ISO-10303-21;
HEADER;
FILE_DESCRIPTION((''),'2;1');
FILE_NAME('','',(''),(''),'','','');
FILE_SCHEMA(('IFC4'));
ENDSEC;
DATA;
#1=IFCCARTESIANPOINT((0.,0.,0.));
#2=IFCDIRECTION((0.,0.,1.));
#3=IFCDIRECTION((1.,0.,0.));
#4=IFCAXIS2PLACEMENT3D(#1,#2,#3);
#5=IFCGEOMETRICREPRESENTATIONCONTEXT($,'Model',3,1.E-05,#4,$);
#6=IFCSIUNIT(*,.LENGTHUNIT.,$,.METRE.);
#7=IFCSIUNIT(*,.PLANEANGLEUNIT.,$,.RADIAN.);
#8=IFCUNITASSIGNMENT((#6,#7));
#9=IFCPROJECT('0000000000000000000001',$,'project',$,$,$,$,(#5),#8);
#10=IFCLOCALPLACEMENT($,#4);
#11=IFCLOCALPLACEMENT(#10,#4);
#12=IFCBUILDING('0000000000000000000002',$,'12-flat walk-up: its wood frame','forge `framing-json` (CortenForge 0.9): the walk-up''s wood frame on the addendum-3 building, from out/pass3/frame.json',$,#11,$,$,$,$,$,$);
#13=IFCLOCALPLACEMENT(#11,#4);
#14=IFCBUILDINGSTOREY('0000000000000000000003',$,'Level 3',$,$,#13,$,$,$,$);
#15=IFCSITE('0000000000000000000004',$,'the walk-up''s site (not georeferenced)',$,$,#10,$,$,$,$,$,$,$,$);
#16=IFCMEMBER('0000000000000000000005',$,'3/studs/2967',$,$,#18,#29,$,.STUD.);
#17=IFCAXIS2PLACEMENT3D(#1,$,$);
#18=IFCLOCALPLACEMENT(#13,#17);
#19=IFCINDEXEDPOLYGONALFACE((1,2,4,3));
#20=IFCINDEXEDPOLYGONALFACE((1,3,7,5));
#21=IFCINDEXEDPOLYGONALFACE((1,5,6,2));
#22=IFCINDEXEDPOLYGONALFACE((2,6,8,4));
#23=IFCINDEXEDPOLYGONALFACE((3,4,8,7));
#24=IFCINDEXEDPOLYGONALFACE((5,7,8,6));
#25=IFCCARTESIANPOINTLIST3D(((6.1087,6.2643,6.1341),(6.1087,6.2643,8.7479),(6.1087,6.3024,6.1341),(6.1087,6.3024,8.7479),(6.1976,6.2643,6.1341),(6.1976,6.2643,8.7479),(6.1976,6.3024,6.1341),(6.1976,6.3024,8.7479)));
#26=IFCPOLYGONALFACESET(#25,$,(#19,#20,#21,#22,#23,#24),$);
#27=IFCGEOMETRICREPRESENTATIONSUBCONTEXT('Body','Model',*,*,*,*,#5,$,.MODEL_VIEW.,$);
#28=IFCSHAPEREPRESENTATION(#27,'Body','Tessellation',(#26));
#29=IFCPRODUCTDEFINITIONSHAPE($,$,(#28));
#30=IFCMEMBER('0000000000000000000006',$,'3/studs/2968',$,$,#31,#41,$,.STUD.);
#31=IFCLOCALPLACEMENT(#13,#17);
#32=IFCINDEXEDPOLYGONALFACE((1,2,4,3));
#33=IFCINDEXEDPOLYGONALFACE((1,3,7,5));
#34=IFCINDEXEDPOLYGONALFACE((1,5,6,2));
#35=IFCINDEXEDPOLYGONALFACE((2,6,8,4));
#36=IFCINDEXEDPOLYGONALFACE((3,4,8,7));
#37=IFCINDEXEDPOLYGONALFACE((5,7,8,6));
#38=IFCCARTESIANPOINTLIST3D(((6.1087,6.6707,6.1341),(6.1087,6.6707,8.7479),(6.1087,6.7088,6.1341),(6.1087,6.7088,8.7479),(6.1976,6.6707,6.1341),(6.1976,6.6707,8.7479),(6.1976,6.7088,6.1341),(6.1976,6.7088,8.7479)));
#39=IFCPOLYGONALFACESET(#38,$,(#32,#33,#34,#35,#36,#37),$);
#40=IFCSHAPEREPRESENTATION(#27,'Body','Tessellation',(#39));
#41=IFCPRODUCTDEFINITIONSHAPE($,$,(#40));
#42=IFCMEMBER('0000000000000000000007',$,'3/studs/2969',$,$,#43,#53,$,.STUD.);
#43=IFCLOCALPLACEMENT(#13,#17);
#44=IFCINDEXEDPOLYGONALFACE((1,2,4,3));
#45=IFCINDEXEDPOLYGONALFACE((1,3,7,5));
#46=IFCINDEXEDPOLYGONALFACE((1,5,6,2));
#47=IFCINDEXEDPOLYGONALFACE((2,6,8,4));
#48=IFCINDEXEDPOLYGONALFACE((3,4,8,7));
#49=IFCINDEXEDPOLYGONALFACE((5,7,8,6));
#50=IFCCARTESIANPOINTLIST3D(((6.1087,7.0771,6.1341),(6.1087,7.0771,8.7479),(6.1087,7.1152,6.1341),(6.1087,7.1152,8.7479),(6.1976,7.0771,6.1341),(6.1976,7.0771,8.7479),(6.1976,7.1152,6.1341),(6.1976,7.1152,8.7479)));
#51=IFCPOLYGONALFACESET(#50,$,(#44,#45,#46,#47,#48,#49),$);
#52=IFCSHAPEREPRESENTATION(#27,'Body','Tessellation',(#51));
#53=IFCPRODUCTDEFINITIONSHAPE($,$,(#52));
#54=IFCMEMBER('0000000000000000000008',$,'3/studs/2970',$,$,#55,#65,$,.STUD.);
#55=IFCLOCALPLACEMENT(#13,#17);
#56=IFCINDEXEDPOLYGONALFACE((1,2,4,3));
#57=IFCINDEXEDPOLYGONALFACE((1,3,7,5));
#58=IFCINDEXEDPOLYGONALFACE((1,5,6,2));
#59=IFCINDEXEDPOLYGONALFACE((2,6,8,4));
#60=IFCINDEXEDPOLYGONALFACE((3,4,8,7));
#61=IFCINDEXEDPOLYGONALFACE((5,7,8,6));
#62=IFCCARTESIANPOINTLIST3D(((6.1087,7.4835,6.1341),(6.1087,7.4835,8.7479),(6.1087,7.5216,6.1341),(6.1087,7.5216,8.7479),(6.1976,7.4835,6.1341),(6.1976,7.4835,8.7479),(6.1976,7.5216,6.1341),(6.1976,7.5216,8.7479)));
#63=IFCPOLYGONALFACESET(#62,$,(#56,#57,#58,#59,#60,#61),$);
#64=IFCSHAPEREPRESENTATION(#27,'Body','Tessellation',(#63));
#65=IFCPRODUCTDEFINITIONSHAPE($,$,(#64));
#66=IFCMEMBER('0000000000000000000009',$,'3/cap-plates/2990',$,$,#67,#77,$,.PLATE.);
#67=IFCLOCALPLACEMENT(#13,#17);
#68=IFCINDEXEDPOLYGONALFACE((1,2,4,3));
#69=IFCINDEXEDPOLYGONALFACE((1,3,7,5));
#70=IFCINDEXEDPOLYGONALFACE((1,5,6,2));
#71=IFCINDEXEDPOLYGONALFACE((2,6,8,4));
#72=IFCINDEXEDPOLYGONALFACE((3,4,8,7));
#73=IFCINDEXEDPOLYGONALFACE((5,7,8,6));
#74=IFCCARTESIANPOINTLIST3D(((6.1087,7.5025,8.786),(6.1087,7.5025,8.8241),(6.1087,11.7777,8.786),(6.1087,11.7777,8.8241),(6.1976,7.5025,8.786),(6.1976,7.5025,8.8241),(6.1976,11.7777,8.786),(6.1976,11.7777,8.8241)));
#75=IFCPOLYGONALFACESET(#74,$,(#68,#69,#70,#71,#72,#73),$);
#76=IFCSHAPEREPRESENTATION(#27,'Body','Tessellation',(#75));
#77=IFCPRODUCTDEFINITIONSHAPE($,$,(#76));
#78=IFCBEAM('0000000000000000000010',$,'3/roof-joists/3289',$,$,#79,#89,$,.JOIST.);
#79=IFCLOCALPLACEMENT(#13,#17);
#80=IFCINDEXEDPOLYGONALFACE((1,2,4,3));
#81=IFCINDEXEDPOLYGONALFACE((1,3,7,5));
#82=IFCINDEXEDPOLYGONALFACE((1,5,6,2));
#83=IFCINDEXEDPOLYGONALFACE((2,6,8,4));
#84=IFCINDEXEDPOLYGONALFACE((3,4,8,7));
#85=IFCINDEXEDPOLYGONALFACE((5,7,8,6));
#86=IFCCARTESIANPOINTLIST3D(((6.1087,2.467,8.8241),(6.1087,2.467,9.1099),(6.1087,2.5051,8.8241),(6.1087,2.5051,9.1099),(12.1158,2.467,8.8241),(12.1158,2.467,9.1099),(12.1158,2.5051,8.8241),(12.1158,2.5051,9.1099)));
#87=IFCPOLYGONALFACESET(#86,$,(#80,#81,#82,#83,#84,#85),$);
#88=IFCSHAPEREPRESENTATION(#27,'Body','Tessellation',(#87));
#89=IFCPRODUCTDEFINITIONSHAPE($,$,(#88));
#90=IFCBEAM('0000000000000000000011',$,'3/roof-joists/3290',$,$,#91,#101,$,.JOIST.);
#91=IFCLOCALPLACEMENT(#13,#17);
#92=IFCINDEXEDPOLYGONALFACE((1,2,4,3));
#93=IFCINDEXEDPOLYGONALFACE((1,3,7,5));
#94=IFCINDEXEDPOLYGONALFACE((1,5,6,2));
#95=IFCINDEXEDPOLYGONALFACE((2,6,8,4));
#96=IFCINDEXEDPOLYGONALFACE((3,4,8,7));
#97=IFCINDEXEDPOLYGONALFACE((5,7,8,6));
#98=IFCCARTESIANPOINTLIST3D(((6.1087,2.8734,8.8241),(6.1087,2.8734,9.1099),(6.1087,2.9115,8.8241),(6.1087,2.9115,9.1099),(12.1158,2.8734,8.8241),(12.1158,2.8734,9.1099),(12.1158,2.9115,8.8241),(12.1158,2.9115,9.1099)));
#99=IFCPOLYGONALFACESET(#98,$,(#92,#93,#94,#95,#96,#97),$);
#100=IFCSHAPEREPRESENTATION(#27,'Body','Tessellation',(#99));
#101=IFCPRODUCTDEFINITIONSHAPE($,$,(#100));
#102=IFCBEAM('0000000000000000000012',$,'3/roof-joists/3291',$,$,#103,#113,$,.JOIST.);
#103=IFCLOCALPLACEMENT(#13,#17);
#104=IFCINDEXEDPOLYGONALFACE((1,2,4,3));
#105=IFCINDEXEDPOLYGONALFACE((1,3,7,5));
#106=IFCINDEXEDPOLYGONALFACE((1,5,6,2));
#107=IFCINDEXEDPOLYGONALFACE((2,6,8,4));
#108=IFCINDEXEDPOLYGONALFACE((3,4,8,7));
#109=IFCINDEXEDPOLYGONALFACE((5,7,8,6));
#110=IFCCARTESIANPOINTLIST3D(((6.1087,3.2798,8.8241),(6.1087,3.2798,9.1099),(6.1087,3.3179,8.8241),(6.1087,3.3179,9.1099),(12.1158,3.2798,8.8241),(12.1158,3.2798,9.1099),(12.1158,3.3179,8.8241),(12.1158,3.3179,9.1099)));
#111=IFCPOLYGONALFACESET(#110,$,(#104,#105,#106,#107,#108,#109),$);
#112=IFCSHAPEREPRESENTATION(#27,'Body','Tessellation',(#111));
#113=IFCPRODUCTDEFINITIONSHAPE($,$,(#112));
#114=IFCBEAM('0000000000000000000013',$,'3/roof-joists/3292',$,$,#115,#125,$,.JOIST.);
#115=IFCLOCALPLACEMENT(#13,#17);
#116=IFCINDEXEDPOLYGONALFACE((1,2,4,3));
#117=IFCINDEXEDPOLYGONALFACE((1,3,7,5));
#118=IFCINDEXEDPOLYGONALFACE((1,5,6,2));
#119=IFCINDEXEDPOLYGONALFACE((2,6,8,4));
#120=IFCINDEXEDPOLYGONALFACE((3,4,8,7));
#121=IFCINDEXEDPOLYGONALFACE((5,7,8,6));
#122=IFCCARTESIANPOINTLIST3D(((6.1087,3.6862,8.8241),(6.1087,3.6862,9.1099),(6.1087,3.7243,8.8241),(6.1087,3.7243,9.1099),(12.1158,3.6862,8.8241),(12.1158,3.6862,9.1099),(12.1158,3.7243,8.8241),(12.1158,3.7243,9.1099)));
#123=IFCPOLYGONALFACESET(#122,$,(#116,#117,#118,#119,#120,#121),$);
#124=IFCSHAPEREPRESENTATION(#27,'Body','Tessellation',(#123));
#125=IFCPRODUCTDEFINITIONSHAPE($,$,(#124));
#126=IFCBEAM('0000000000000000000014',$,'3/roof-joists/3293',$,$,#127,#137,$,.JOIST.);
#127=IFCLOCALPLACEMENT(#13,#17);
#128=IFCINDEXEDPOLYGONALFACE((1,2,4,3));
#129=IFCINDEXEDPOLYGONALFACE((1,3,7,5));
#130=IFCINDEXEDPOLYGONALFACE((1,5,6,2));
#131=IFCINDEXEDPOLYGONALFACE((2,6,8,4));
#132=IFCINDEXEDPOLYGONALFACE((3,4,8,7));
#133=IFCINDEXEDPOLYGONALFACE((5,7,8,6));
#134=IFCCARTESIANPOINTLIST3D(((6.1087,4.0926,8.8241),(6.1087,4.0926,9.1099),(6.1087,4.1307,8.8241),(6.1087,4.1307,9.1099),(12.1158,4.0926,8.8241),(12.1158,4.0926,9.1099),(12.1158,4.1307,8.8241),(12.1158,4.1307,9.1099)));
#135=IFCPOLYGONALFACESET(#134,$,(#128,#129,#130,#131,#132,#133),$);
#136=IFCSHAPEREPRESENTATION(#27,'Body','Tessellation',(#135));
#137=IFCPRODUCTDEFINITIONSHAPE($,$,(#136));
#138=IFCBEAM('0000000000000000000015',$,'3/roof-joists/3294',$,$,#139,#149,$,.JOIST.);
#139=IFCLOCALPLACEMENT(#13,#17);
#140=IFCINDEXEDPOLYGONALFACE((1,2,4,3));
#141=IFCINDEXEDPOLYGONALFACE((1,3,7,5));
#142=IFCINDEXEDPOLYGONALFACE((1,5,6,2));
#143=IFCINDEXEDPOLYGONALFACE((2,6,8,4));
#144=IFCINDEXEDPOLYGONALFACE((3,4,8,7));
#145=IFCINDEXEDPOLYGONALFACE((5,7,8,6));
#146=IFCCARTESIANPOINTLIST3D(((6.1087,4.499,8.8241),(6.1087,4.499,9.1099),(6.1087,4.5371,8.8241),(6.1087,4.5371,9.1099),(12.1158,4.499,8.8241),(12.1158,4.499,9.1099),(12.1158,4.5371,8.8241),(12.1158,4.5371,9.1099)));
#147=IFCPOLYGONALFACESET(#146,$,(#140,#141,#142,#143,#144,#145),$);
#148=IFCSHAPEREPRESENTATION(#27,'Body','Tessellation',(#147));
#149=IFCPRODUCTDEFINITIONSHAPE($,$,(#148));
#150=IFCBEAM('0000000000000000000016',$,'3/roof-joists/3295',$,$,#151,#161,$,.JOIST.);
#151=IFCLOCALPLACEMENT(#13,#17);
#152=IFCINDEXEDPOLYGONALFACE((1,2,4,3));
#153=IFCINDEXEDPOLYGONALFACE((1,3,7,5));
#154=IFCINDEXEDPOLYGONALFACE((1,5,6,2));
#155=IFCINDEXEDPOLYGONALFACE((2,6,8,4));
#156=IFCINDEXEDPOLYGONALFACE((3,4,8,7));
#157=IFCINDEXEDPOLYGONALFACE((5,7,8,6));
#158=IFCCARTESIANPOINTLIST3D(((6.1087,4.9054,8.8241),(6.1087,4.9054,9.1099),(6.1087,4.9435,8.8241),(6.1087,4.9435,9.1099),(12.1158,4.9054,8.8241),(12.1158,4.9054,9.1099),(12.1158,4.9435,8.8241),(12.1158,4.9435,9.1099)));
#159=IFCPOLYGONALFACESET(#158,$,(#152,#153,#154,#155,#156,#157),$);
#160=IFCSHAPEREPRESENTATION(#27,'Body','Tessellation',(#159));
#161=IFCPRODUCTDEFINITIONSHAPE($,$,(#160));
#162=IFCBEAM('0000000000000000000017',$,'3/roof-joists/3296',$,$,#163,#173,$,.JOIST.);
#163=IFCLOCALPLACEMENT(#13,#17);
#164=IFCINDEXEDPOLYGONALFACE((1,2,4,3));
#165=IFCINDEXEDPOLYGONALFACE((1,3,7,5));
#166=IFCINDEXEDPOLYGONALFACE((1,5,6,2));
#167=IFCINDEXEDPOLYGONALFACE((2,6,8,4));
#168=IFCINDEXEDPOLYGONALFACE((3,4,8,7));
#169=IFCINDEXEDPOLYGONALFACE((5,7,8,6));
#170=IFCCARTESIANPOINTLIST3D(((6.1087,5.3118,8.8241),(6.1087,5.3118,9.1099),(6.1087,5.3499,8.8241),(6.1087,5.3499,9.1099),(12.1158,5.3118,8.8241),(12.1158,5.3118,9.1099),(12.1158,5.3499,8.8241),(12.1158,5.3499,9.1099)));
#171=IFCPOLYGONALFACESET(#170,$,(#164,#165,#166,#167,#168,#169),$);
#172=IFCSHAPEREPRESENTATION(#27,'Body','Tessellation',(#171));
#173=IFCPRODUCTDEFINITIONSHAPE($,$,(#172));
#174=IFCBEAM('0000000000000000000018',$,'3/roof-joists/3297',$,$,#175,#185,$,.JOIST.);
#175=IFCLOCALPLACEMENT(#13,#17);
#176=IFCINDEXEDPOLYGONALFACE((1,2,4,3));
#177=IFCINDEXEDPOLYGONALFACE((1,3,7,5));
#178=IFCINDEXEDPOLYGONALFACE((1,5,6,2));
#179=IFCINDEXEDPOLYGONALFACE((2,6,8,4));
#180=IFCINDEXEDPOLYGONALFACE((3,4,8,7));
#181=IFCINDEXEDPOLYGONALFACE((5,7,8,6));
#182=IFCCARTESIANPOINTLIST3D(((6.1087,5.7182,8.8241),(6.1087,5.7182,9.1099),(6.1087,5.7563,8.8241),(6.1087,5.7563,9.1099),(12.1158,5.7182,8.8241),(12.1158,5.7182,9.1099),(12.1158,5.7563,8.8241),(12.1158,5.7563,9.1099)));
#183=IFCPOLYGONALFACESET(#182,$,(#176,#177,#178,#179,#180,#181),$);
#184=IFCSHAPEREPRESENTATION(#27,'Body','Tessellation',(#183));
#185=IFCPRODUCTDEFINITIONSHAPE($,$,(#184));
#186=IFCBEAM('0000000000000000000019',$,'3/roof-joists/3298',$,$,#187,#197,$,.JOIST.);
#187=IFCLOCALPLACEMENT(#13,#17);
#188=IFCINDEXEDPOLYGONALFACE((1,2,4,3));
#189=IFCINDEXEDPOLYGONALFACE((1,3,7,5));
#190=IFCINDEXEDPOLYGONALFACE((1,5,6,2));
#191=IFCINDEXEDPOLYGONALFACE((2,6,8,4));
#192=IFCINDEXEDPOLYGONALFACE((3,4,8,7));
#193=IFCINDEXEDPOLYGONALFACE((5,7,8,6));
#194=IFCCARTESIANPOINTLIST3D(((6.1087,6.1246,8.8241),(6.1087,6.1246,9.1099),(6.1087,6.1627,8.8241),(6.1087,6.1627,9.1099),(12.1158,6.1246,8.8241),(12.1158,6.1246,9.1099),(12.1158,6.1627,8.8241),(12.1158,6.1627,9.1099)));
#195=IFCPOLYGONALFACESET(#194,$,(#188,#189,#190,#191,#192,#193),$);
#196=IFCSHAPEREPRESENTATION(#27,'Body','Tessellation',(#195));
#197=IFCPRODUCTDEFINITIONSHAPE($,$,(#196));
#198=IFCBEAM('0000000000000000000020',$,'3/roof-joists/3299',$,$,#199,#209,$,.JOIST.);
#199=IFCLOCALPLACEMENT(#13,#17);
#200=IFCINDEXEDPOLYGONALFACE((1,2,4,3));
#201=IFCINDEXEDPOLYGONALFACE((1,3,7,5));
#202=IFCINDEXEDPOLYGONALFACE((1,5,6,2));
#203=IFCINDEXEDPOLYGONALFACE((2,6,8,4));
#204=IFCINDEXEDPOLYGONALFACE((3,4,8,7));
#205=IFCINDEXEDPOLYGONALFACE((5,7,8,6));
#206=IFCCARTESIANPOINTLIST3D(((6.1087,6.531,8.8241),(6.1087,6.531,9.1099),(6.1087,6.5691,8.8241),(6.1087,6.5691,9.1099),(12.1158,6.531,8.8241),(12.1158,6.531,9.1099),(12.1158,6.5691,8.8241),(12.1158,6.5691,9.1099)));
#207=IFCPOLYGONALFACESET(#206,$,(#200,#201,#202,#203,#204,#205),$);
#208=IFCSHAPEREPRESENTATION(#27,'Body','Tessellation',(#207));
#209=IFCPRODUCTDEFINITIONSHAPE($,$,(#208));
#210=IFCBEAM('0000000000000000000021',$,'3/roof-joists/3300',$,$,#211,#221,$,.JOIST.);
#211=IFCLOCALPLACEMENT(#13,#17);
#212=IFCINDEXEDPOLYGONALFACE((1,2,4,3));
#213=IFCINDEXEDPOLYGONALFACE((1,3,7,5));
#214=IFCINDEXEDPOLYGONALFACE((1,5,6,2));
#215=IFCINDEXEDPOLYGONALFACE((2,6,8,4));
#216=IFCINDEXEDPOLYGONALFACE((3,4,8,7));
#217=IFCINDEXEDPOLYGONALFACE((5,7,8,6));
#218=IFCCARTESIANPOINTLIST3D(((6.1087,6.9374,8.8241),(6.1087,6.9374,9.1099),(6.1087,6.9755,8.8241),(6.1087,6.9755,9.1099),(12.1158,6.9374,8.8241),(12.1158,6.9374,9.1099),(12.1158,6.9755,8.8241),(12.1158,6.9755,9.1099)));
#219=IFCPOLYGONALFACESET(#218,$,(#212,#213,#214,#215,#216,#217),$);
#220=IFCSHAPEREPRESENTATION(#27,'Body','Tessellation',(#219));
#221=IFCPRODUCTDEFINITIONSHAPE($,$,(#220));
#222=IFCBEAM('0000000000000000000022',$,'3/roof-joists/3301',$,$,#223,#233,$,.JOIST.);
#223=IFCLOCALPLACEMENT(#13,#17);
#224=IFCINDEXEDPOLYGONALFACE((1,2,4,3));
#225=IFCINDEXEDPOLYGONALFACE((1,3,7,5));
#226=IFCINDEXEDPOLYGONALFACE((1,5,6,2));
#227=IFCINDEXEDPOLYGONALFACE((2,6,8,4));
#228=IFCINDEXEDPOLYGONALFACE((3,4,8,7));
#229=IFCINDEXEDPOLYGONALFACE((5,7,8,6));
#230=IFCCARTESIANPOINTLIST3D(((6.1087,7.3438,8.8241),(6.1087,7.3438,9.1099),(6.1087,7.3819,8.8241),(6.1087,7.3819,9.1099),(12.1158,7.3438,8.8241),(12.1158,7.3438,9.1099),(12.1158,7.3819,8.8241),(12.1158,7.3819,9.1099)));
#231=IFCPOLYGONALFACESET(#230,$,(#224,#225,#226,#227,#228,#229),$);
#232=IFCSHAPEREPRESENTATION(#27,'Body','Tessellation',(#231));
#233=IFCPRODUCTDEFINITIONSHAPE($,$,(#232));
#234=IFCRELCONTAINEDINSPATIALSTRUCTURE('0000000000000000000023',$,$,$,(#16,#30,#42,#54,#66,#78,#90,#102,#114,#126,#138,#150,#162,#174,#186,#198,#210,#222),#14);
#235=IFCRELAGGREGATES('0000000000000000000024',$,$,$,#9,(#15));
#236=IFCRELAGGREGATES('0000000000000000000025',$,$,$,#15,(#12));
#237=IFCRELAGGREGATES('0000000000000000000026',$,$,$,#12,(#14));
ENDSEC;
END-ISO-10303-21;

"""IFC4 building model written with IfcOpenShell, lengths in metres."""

from ifc_helpers import new_model, si_unit, frame, frame_2d, origin, origin_with_axes, place, context, subcontext, project, spatial, rectangle, extrude, element, save


model = new_model("IFC4")

# Units and contexts
model_context = context("Model", 3, precision=1e-05, world=origin_with_axes())
body_context = subcontext(model_context, "Body", "Model", "MODEL_VIEW")
ifc_project = project(units=[si_unit("LENGTHUNIT", "METRE"), si_unit("PLANEANGLEUNIT", "RADIAN")], contexts=[model_context])

# Site, building, storey
site_placement = place(None, origin_with_axes())
site = spatial("IfcSite", under=ifc_project, at=site_placement, Name="the walk-up's site (not georeferenced)")
building_placement = place(site_placement, origin_with_axes())
building = spatial("IfcBuilding", under=site, at=building_placement, Name="12-flat walk-up: its wood frame", Description="forge `framing-json` (CortenForge 0.9): the walk-up's wood frame on the addendum-3 building, from out/pass3/frame.json")
storey_placement = place(building_placement, origin_with_axes())
storey = spatial("IfcBuildingStorey", under=building, at=storey_placement, Name="Level 3")

# Members
for number, where, z_axis, x_axis, name in (
    (1, (6.1087, 6.2643, 6.1341), (0.0, 0.0, 1.0), (1.0, 0.0, 0.0), "3/studs/2967"),
    (2, (6.1087, 6.6707, 6.1341), (0.0, 0.0, 1.0), (1.0, 0.0, 0.0), "3/studs/2968"),
    (3, (6.1087, 7.0771, 6.1341), (0.0, 0.0, 1.0), (1.0, 0.0, 0.0), "3/studs/2969"),
    (4, (6.1087, 7.4835, 6.1341), (0.0, 0.0, 1.0), (1.0, 0.0, 0.0), "3/studs/2970"),
):
    element("IfcMember", number, at=place(storey_placement, frame(where, z_axis=z_axis, x_axis=x_axis)), inside=storey, Name=name, PredefinedType="STUD", context=body_context, shape_type="SweptSolid", body=[
        extrude(rectangle(XDim=0.0889, YDim=0.0381, at=frame_2d((0.0445, 0.0191))), origin(), (0.0, 0.0, 1.0), 2.6138),
    ])
member_1_placement = place(storey_placement, frame((6.1087, 7.5025, 8.786), z_axis=(0.0, 0.0, 1.0), x_axis=(1.0, 0.0, 0.0)))
element("IfcMember", 5, at=member_1_placement, inside=storey, Name="3/cap-plates/2990", PredefinedType="PLATE", context=body_context, shape_type="SweptSolid", body=[
    extrude(rectangle(XDim=0.0889, YDim=4.2751, at=frame_2d((0.0445, 2.1376))), origin(), (0.0, 0.0, 1.0), 0.0381),
])

# Beams
for number, where, z_axis, x_axis, name in (
    (6, (6.1087, 2.467, 8.8241), (0.0, 0.0, 1.0), (1.0, 0.0, 0.0), "3/roof-joists/3289"),
    (7, (6.1087, 2.8734, 8.8241), (0.0, 0.0, 1.0), (1.0, 0.0, 0.0), "3/roof-joists/3290"),
    (8, (6.1087, 3.2798, 8.8241), (0.0, 0.0, 1.0), (1.0, 0.0, 0.0), "3/roof-joists/3291"),
    (9, (6.1087, 3.6862, 8.8241), (0.0, 0.0, 1.0), (1.0, 0.0, 0.0), "3/roof-joists/3292"),
    (10, (6.1087, 4.0926, 8.8241), (0.0, 0.0, 1.0), (1.0, 0.0, 0.0), "3/roof-joists/3293"),
    (11, (6.1087, 4.499, 8.8241), (0.0, 0.0, 1.0), (1.0, 0.0, 0.0), "3/roof-joists/3294"),
    (12, (6.1087, 4.9054, 8.8241), (0.0, 0.0, 1.0), (1.0, 0.0, 0.0), "3/roof-joists/3295"),
    (13, (6.1087, 5.3118, 8.8241), (0.0, 0.0, 1.0), (1.0, 0.0, 0.0), "3/roof-joists/3296"),
    (14, (6.1087, 5.7182, 8.8241), (0.0, 0.0, 1.0), (1.0, 0.0, 0.0), "3/roof-joists/3297"),
    (15, (6.1087, 6.1246, 8.8241), (0.0, 0.0, 1.0), (1.0, 0.0, 0.0), "3/roof-joists/3298"),
    (16, (6.1087, 6.531, 8.8241), (0.0, 0.0, 1.0), (1.0, 0.0, 0.0), "3/roof-joists/3299"),
    (17, (6.1087, 6.9374, 8.8241), (0.0, 0.0, 1.0), (1.0, 0.0, 0.0), "3/roof-joists/3300"),
    (18, (6.1087, 7.3438, 8.8241), (0.0, 0.0, 1.0), (1.0, 0.0, 0.0), "3/roof-joists/3301"),
):
    element("IfcBeam", number, at=place(storey_placement, frame(where, z_axis=z_axis, x_axis=x_axis)), inside=storey, Name=name, PredefinedType="JOIST", context=body_context, shape_type="SweptSolid", body=[
        extrude(rectangle(XDim=6.0071, YDim=0.0381, at=frame_2d((3.0036, 0.0191))), origin(), (0.0, 0.0, 1.0), 0.2858),
    ])

save(model, "model.ifc")
